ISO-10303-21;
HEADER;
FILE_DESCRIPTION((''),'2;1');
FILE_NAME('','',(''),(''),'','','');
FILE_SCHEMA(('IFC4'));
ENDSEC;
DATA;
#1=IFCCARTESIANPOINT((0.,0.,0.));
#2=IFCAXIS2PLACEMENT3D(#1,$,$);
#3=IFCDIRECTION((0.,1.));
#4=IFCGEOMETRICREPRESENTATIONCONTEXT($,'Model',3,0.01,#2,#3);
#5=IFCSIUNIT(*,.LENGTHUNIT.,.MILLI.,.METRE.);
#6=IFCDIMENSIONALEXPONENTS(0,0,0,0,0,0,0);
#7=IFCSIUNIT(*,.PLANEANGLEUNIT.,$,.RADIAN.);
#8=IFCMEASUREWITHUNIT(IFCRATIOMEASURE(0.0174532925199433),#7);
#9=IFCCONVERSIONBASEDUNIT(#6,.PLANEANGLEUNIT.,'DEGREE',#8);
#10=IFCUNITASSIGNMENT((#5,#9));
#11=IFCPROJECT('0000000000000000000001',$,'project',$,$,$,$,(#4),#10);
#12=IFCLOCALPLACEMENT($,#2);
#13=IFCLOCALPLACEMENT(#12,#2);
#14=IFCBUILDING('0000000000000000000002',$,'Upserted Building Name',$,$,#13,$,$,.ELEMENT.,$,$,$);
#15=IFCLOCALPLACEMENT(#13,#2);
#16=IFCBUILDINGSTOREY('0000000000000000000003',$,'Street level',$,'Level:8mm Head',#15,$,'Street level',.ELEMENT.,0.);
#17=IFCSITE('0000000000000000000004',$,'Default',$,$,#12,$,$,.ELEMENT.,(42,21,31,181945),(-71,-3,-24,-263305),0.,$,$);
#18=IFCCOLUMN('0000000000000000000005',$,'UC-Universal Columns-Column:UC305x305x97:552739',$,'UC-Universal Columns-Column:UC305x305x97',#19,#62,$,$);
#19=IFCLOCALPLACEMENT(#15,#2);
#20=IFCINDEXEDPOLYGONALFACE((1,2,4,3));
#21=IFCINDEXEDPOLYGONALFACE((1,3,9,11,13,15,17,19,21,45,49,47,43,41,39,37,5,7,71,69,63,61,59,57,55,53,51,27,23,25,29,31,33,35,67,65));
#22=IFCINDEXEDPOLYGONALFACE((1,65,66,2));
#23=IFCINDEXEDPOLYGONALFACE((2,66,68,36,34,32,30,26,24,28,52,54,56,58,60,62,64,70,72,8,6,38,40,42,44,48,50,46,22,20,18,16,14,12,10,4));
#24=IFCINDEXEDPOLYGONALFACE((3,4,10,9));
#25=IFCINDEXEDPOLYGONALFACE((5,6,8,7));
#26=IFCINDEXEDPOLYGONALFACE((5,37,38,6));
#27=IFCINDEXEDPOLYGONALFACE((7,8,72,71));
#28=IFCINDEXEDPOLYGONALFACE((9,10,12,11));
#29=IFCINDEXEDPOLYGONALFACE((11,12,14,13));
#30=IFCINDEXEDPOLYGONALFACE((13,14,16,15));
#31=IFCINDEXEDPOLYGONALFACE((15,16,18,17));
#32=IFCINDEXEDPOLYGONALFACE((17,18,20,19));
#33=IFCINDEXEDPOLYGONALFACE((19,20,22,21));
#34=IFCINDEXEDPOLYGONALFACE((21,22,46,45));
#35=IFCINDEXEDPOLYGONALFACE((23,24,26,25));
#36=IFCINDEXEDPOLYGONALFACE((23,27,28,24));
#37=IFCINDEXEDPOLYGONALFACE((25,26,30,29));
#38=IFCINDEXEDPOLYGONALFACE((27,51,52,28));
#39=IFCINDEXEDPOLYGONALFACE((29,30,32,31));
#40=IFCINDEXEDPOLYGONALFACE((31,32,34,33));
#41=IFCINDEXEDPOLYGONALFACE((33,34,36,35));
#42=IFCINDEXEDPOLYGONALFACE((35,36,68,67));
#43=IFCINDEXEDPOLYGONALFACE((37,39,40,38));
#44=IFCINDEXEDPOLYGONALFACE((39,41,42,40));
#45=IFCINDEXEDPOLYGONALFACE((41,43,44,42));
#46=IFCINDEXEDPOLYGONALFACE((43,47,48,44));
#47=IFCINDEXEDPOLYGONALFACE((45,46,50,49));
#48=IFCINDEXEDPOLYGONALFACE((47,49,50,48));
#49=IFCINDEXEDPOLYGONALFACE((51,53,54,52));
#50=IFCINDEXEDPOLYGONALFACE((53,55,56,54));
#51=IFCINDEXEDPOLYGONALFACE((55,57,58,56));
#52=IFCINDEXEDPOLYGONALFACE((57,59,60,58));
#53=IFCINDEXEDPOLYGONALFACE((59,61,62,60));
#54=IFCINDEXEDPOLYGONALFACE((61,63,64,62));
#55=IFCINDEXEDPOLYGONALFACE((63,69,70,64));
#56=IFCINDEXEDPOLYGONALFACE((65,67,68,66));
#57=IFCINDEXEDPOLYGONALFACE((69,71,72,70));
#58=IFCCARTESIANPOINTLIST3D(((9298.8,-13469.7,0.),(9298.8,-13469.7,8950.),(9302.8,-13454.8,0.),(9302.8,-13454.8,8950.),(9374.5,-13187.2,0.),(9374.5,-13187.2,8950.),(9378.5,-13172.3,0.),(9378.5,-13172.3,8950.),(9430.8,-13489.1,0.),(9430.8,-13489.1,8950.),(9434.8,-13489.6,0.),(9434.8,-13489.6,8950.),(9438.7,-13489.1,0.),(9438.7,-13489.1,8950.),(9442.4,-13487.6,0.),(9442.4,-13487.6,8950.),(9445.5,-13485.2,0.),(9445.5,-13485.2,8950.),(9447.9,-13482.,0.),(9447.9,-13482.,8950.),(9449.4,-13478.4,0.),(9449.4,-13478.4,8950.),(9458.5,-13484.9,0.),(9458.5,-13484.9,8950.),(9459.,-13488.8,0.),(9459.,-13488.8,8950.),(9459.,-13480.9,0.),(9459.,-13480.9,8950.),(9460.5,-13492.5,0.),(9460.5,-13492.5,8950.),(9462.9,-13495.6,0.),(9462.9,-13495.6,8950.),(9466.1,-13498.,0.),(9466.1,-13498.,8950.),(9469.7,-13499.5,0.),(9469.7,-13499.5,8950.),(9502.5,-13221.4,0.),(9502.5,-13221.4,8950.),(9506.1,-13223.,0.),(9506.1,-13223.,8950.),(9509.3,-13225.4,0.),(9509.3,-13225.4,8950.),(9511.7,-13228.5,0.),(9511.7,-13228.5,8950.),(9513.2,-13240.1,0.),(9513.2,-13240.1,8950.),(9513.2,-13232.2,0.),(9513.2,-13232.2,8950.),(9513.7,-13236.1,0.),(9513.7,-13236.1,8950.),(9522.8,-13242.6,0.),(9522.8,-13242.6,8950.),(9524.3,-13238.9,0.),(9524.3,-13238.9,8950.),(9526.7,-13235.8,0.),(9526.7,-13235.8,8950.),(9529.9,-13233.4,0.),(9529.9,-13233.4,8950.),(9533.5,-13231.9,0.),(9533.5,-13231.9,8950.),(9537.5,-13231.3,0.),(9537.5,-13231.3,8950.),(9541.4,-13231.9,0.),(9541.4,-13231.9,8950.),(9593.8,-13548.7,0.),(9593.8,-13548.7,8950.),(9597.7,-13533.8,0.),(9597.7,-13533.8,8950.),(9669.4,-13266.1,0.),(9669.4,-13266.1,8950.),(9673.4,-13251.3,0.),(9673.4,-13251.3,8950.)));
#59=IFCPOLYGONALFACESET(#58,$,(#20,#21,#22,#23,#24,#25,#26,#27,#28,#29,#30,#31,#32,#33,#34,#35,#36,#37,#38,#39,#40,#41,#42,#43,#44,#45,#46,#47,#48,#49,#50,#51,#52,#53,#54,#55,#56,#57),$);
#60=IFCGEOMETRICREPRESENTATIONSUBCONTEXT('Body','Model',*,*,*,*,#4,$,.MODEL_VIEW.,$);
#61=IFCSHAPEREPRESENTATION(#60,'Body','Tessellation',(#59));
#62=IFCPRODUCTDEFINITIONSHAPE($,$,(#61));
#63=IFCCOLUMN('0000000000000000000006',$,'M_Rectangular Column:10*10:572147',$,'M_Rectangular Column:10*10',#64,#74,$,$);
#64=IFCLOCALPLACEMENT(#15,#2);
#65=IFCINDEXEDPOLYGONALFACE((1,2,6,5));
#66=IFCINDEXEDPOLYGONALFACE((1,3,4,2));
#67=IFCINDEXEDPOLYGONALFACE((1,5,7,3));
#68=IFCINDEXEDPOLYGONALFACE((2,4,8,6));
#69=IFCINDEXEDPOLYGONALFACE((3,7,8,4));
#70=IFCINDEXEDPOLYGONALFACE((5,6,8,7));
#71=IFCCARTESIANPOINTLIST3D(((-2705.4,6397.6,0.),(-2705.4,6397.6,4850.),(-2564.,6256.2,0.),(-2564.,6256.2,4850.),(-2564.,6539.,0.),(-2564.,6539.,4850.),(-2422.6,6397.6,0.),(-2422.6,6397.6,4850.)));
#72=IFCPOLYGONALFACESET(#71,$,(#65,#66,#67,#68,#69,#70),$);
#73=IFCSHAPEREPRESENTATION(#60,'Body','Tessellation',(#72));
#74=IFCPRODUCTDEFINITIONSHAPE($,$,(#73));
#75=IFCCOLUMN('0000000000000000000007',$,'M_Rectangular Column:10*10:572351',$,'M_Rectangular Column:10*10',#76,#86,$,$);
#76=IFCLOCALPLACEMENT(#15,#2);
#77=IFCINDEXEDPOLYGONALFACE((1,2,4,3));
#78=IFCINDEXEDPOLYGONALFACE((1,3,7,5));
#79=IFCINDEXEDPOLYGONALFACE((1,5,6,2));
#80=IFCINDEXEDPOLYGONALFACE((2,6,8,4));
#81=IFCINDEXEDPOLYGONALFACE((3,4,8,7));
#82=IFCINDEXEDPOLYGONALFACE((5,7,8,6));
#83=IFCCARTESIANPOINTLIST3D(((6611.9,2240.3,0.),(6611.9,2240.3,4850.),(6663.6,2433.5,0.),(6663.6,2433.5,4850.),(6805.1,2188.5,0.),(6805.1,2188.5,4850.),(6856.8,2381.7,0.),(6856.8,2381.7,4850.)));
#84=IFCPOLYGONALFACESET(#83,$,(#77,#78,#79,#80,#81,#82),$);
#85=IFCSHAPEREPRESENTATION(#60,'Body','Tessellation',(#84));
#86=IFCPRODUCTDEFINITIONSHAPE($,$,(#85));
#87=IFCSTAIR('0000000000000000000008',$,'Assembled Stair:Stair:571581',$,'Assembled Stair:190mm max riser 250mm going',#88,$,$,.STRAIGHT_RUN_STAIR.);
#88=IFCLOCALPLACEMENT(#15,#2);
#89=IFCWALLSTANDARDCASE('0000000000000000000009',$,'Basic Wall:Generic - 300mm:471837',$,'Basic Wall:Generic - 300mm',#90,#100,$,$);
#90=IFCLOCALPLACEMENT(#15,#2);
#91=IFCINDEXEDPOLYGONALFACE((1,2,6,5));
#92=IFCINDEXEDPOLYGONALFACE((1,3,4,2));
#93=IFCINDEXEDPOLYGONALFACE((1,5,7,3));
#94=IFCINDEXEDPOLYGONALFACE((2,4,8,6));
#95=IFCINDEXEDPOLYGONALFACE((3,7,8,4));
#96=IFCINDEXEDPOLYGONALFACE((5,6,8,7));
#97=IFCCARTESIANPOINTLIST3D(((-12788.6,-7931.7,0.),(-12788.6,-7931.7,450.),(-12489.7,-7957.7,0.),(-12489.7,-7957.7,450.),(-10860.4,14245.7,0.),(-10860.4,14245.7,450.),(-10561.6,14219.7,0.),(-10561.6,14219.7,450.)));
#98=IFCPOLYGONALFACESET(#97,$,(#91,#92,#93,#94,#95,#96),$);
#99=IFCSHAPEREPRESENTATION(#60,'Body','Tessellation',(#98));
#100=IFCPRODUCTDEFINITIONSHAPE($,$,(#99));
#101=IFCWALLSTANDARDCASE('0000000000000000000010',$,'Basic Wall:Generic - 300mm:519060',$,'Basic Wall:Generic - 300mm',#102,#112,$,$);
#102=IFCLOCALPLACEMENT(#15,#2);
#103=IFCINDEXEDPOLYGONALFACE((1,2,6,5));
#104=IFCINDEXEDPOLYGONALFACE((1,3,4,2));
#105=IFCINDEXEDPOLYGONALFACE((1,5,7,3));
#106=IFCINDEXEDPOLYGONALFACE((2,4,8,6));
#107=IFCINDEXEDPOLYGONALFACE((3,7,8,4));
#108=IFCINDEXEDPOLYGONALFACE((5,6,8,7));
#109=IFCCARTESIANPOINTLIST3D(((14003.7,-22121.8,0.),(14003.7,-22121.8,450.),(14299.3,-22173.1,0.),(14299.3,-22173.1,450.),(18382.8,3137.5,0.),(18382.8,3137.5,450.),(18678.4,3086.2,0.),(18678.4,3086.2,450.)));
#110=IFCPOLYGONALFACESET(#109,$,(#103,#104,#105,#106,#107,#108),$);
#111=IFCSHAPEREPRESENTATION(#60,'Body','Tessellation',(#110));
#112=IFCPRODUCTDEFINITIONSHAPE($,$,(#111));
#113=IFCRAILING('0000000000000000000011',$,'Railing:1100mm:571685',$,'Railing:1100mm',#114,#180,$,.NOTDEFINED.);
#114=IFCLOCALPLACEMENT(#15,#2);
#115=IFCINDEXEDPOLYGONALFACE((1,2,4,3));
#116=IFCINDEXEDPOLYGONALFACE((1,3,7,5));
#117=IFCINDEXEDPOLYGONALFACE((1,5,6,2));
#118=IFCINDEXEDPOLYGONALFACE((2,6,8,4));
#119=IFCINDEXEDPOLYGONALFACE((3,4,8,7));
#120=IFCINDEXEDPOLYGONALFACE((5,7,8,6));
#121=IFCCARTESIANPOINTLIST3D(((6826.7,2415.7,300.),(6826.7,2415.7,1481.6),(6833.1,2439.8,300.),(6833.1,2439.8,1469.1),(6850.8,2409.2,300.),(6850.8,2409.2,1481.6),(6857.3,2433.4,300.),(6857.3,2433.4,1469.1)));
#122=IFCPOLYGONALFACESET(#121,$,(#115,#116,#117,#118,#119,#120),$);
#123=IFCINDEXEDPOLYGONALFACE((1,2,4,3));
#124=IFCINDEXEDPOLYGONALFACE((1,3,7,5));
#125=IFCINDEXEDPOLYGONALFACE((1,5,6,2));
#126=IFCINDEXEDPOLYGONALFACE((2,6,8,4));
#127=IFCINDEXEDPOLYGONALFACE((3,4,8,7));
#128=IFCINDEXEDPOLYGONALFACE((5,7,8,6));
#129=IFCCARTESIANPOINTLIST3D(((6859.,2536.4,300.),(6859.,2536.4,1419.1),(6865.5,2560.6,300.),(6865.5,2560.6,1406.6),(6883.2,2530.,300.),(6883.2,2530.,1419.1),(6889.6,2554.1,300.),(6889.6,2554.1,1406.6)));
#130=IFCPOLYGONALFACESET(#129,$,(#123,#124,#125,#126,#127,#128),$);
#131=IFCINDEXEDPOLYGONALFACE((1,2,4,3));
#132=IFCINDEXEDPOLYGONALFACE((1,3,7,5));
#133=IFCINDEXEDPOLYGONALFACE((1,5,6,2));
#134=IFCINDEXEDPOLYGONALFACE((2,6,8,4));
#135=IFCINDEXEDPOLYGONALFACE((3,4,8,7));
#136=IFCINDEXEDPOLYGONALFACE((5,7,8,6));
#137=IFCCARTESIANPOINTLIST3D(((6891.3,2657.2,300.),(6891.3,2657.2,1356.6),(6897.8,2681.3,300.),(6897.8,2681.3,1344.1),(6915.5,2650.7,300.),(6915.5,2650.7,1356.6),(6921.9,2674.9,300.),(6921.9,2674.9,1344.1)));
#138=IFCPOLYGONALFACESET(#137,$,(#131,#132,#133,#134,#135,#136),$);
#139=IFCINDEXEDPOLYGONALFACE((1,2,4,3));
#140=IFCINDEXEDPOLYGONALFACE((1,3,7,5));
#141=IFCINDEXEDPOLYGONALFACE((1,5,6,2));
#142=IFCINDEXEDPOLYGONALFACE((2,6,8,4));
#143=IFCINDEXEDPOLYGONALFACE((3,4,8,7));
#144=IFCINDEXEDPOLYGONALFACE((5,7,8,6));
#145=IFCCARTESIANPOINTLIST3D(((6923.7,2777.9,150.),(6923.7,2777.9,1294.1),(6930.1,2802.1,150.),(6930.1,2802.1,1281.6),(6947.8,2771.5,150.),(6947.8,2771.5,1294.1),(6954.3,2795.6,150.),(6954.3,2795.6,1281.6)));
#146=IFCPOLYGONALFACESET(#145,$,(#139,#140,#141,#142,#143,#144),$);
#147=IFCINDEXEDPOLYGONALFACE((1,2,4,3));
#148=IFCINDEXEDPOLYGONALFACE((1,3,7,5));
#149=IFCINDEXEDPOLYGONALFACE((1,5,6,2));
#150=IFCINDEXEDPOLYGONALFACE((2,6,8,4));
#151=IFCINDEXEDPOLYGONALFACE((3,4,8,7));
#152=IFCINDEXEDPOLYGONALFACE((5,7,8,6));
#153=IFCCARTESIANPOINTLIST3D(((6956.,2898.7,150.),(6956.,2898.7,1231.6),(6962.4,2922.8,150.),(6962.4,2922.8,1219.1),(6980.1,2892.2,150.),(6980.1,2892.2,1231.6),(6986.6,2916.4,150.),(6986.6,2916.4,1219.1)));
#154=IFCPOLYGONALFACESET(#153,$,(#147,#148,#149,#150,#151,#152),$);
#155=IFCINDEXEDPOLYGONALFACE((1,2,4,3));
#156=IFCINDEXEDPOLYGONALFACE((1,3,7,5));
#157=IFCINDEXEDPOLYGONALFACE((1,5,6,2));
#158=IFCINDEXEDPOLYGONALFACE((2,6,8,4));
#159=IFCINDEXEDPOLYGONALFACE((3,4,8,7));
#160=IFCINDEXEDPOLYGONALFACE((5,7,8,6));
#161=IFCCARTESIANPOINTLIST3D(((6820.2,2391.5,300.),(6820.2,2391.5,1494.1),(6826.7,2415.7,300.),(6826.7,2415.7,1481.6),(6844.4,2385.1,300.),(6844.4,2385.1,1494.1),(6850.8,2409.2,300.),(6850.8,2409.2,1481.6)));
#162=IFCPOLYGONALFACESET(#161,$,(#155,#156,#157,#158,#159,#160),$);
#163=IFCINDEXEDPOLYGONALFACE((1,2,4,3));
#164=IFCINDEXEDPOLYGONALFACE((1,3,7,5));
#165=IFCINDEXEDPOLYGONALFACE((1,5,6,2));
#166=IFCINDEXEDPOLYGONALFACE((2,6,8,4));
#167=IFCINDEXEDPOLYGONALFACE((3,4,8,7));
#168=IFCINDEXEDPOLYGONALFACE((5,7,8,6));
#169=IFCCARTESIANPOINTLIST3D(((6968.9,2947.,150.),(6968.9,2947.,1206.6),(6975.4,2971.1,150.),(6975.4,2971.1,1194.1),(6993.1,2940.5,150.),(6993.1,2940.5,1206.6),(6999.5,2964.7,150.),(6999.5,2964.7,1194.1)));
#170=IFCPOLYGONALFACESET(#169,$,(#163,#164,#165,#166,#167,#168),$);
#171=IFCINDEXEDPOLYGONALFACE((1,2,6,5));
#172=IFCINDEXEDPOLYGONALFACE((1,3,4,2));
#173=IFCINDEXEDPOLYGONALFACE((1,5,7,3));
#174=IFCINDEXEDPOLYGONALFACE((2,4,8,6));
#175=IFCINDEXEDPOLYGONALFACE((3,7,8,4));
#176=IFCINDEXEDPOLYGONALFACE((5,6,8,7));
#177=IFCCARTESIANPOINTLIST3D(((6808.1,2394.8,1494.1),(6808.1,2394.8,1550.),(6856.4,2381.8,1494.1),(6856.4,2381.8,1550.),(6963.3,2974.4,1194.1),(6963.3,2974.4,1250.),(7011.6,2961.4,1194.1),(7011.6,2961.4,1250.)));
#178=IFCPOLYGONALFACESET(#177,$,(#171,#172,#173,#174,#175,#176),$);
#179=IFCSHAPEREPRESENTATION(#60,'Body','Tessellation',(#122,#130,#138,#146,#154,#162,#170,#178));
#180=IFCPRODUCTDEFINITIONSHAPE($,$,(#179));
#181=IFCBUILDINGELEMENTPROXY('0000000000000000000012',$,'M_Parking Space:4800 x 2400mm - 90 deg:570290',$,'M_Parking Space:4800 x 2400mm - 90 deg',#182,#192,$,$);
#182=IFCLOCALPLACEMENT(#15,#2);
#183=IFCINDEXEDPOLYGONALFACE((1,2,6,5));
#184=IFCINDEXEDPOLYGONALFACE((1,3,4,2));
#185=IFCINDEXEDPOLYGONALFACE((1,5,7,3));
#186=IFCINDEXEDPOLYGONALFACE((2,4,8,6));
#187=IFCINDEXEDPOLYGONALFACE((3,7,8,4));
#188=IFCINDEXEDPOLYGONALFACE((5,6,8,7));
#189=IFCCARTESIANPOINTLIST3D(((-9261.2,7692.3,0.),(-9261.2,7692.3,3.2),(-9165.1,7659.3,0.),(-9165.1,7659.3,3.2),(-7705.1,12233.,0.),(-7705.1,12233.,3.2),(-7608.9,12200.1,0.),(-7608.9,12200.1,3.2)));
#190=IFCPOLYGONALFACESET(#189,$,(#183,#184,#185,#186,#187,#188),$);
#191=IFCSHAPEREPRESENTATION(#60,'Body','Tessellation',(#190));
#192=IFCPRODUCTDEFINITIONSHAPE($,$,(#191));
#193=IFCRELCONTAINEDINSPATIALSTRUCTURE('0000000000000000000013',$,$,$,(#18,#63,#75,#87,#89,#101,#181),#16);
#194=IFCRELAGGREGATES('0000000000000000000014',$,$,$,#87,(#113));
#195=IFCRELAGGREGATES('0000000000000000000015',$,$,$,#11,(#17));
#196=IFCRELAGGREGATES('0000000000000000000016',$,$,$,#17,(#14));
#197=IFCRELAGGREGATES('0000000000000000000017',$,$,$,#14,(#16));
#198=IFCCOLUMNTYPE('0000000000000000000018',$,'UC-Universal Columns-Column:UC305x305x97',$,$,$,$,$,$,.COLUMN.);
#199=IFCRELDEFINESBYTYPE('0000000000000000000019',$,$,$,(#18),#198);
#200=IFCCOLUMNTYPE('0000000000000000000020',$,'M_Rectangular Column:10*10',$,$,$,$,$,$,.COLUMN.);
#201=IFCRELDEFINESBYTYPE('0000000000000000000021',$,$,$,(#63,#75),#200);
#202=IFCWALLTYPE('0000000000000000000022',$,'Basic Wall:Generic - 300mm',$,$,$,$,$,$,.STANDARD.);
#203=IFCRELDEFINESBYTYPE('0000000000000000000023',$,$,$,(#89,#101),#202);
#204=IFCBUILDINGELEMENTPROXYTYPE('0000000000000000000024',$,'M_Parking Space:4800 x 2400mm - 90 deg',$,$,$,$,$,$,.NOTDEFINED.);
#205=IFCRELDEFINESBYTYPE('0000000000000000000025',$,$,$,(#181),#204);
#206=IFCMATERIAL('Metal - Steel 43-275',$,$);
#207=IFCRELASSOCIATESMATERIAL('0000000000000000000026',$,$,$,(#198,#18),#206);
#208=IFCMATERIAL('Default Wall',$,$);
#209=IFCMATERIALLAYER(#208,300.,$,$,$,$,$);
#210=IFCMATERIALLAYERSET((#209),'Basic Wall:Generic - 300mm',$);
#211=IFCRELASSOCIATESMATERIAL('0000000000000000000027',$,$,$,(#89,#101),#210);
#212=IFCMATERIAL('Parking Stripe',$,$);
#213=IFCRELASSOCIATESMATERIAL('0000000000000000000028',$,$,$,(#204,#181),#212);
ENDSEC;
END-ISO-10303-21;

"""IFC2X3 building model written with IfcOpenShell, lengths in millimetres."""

from ifc_helpers import new_model, entity, si_unit, converted_unit, direction, frame, frame_2d, origin, origin_2d_with_axis, place, context, subcontext, project, spatial, polyline, rectangle, i_section, outline, extrude, source, transform, mapped, material, layer, layer_set, layer_usage, type_object, type_shapes, element, aggregate, save


model = new_model("IFC2X3")

# Units and contexts
model_context = context("Model", 3, precision=0.01, world=origin(), true_north=direction((0.0, 1.0)))
body_context = subcontext(model_context, "Body", "Model", "MODEL_VIEW")
ifc_project = project(units=[si_unit("LENGTHUNIT", "METRE", prefix="MILLI"), converted_unit("PLANEANGLEUNIT", "DEGREE", entity("IfcRatioMeasure", 0.0174532925199433), si_unit("PLANEANGLEUNIT", "RADIAN"), dimensions=[0, 0, 0, 0, 0, 0, 0])], contexts=[model_context])

# Site, building, storey
site_placement = place(None, origin())
site = spatial("IfcSite", under=ifc_project, at=site_placement, Name="Default", CompositionType="ELEMENT", RefLatitude=(42, 21, 31, 181945), RefLongitude=(-71, -3, -24, -263305), RefElevation=0.0)
building_placement = place(site_placement, origin())
building = spatial("IfcBuilding", under=site, at=building_placement, Name="Upserted Building Name", CompositionType="ELEMENT")
storey_placement = place(building_placement, origin())
storey = spatial("IfcBuildingStorey", under=building, at=storey_placement, Name="Street level", ObjectType="Level:8mm Head", LongName="Street level", CompositionType="ELEMENT", Elevation=0.0)

# Columns
ifc_material_1 = material(Name="Metal - Steel 43-275")
column_type_1 = type_object("IfcColumnType", Name="UC-Universal Columns-Column:UC305x305x97", PredefinedType="COLUMN", material=ifc_material_1)
shared_shape_1 = source(origin(), body_context, "Body", "SweptSolid", [
    extrude(i_section(OverallWidth=305.3, OverallDepth=307.9, WebThickness=9.9, FlangeThickness=15.4, FilletRadius=15.2, at=frame_2d((0.0, 0.0), x_axis=(0.0, 1.0))), frame((0.0, 0.0, 0.0), z_axis=(0.0, 0.0, 1.0), x_axis=(0.0, -1.0, 0.0)), (0.0, 0.0, 1.0), 8950.0),
])
type_shapes(column_type_1, [shared_shape_1])
column_placement = place(storey_placement, frame((9486.1, -13360.5, 0.0), z_axis=(0.0, 0.0, 1.0), x_axis=(0.965983, -0.258607, 0.0)))
element("IfcColumn", 1, at=column_placement, inside=storey, type_object=column_type_1, material=ifc_material_1, Name="UC-Universal Columns-Column:UC305x305x97:552739", ObjectType="UC-Universal Columns-Column:UC305x305x97", context=body_context, shape_type="MappedRepresentation", body=[
    mapped(shared_shape_1, transform((0.0, 0.0, 0.0), scale=1.0)),
])
column_type_2 = type_object("IfcColumnType", Name="M_Rectangular Column:10*10", PredefinedType="COLUMN")
shared_shape_2 = source(origin(), body_context, "Body", "SweptSolid", [
    extrude(rectangle(XDim=200.0, YDim=200.0, at=origin_2d_with_axis()), frame((0.0, 0.0, 0.0), z_axis=(0.0, 0.0, 1.0), x_axis=(0.0, -1.0, 0.0)), (0.0, 0.0, 1.0), 4850.0),
])
type_shapes(column_type_2, [shared_shape_2])
for number, where, z_axis, x_axis, name in (
    (2, (-2564.0, 6397.6, 0.0), (0.0, 0.0, 1.0), (0.707107, 0.707107, 0.0), "M_Rectangular Column:10*10:572147"),
    (3, (6734.4, 2311.0, 0.0), (0.0, 0.0, 1.0), (0.258607, 0.965983, 0.0), "M_Rectangular Column:10*10:572351"),
):
    element("IfcColumn", number, at=place(storey_placement, frame(where, z_axis=z_axis, x_axis=x_axis)), inside=storey, type_object=column_type_2, Name=name, ObjectType="M_Rectangular Column:10*10", context=body_context, shape_type="MappedRepresentation", body=[
        mapped(shared_shape_2, transform((0.0, 0.0, 0.0), scale=1.0)),
    ])

# Stair
stair_placement = place(storey_placement, origin())
stair = element("IfcStair", 4, at=stair_placement, inside=storey, Name="Assembled Stair:Stair:571581", ObjectType="Assembled Stair:190mm max riser 250mm going", ShapeType="STRAIGHT_RUN_STAIR")

# Walls
ifc_material_2 = material(Name="Default Wall")
ifc_layer_1 = layer(ifc_material_2, 300.0)
ifc_layer_set_1 = layer_set([ifc_layer_1], Name="Basic Wall:Generic - 300mm")
ifc_layer_usage_1 = layer_usage(ifc_layer_set_1, "AXIS2", "NEGATIVE", 150.0)
wall_type = type_object("IfcWallType", Name="Basic Wall:Generic - 300mm", PredefinedType="STANDARD")
wall_1_placement = place(storey_placement, frame((-10711.0, 14232.7, 0.0), z_axis=(0.0, 0.0, 1.0), x_axis=(-0.086615, -0.996242, 0.0)))
element("IfcWallStandardCase", 5, at=wall_1_placement, inside=storey, type_object=wall_type, material=ifc_layer_usage_1, Name="Basic Wall:Generic - 300mm:471837", ObjectType="Basic Wall:Generic - 300mm", context=body_context, shape_type="SweptSolid", body=[
    extrude(rectangle(XDim=22261.1, YDim=300.0, at=frame_2d((11130.5, 0.0), x_axis=(-1.0, 0.0))), origin(), (0.0, 0.0, 1.0), 450.0),
])
ifc_layer_usage_2 = layer_usage(ifc_layer_set_1, "AXIS2", "NEGATIVE", 150.0)
wall_2_placement = place(storey_placement, frame((14151.5, -22147.4, 0.0), z_axis=(0.0, 0.0, 1.0), x_axis=(0.17082, 0.985302, 0.0)))
element("IfcWallStandardCase", 6, at=wall_2_placement, inside=storey, type_object=wall_type, material=ifc_layer_usage_2, Name="Basic Wall:Generic - 300mm:519060", ObjectType="Basic Wall:Generic - 300mm", context=body_context, shape_type="SweptSolid", body=[
    extrude(rectangle(XDim=25636.1, YDim=300.0, at=frame_2d((12818.0, 0.0), x_axis=(-1.0, 0.0))), origin(), (0.0, 0.0, 1.0), 450.0),
])

# Railing
railing_placement = place(stair_placement, origin())
railing = element("IfcRailing", 7, at=railing_placement, Name="Railing:1100mm:571685", ObjectType="Railing:1100mm", PredefinedType="NOTDEFINED", context=body_context, shape_type="SweptSolid", body=[
    extrude(outline(polyline([(-587.7, -12.5), (581.4, -12.5), (593.9, 12.5), (-587.7, 12.5), (-587.7, -12.5)])), frame((6829.9, 2427.8, 887.7), z_axis=(0.965983, -0.258606, 0.0), x_axis=(0.0, 0.0, 1.0)), (0.0, 0.0, 1.0), 25.0),
    extrude(outline(polyline([(-556.4, -12.5), (550.2, -12.5), (562.7, 12.5), (-556.4, 12.5), (-556.4, -12.5)])), frame((6862.2, 2548.5, 856.4), z_axis=(0.965983, -0.258606, 0.0), x_axis=(0.0, 0.0, 1.0)), (0.0, 0.0, 1.0), 25.0),
    extrude(outline(polyline([(-525.2, -12.5), (518.9, -12.5), (531.4, 12.5), (-525.2, 12.5), (-525.2, -12.5)])), frame((6894.6, 2669.3, 825.2), z_axis=(0.965983, -0.258606, 0.0), x_axis=(0.0, 0.0, 1.0)), (0.0, 0.0, 1.0), 25.0),
    extrude(outline(polyline([(-568.9, -12.5), (562.7, -12.5), (575.2, 12.5), (-568.9, 12.5), (-568.9, -12.5)])), frame((6926.9, 2790.0, 718.9), z_axis=(0.965983, -0.258606, 0.0), x_axis=(0.0, 0.0, 1.0)), (0.0, 0.0, 1.0), 25.0),
    extrude(outline(polyline([(-537.7, -12.5), (531.4, -12.5), (543.9, 12.5), (-537.7, 12.5), (-537.7, -12.5)])), frame((6959.2, 2910.8, 687.7), z_axis=(0.965983, -0.258606, 0.0), x_axis=(0.0, 0.0, 1.0)), (0.0, 0.0, 1.0), 25.0),
    extrude(outline(polyline([(-593.9, -12.5), (587.7, -12.5), (600.2, 12.5), (-593.9, 12.5), (-593.9, -12.5)])), frame((6823.4, 2403.6, 893.9), z_axis=(0.965983, -0.258606, 0.0), x_axis=(0.0, 0.0, 1.0)), (0.0, 0.0, 1.0), 25.0),
    extrude(outline(polyline([(-525.2, -12.5), (518.9, -12.5), (531.4, 12.5), (-525.2, 12.5), (-525.2, -12.5)])), frame((6972.1, 2959.1, 675.2), z_axis=(0.965983, -0.258606, 0.0), x_axis=(0.0, 0.0, 1.0)), (0.0, 0.0, 1.0), 25.0),
    extrude(outline(polyline([(-322.9, -25.0), (347.9, -25.0), (322.9, 25.0), (-347.9, 25.0), (-322.9, -25.0)])), frame((6885.7, 2684.6, 1372.0), z_axis=(0.965983, -0.258606, 0.0), x_axis=(-0.231304, -0.864001, 0.447214)), (0.0, 0.0, 1.0), 50.0),
])
aggregate(stair, [railing])

# Building element proxy
ifc_material_3 = material(Name="Parking Stripe")
building_element_proxy_type = type_object("IfcBuildingElementProxyType", Name="M_Parking Space:4800 x 2400mm - 90 deg", PredefinedType="NOTDEFINED", material=ifc_material_3)
shared_shape_3 = source(origin(), body_context, "Body", "SweptSolid", [
    extrude(rectangle(XDim=101.6, YDim=4800.0, at=origin_2d_with_axis()), frame((0.0, 2400.0, 0.0)), (0.0, 0.0, 1.0), 3.2),
])
type_shapes(building_element_proxy_type, [shared_shape_3])
for number, where, z_axis, x_axis, name in (
    (8, (-9213.1, 7675.8, 0.0), (0.0, 0.0, 1.0), (0.945989, -0.324198, 0.0), "M_Parking Space:4800 x 2400mm - 90 deg:570290"),
):
    element("IfcBuildingElementProxy", number, at=place(storey_placement, frame(where, z_axis=z_axis, x_axis=x_axis)), inside=storey, type_object=building_element_proxy_type, material=ifc_material_3, Name=name, ObjectType="M_Parking Space:4800 x 2400mm - 90 deg", context=body_context, shape_type="MappedRepresentation", body=[
        mapped(shared_shape_3, transform((0.0, 0.0, 0.0), scale=1.0)),
    ])

save(model, "model.ifc")
